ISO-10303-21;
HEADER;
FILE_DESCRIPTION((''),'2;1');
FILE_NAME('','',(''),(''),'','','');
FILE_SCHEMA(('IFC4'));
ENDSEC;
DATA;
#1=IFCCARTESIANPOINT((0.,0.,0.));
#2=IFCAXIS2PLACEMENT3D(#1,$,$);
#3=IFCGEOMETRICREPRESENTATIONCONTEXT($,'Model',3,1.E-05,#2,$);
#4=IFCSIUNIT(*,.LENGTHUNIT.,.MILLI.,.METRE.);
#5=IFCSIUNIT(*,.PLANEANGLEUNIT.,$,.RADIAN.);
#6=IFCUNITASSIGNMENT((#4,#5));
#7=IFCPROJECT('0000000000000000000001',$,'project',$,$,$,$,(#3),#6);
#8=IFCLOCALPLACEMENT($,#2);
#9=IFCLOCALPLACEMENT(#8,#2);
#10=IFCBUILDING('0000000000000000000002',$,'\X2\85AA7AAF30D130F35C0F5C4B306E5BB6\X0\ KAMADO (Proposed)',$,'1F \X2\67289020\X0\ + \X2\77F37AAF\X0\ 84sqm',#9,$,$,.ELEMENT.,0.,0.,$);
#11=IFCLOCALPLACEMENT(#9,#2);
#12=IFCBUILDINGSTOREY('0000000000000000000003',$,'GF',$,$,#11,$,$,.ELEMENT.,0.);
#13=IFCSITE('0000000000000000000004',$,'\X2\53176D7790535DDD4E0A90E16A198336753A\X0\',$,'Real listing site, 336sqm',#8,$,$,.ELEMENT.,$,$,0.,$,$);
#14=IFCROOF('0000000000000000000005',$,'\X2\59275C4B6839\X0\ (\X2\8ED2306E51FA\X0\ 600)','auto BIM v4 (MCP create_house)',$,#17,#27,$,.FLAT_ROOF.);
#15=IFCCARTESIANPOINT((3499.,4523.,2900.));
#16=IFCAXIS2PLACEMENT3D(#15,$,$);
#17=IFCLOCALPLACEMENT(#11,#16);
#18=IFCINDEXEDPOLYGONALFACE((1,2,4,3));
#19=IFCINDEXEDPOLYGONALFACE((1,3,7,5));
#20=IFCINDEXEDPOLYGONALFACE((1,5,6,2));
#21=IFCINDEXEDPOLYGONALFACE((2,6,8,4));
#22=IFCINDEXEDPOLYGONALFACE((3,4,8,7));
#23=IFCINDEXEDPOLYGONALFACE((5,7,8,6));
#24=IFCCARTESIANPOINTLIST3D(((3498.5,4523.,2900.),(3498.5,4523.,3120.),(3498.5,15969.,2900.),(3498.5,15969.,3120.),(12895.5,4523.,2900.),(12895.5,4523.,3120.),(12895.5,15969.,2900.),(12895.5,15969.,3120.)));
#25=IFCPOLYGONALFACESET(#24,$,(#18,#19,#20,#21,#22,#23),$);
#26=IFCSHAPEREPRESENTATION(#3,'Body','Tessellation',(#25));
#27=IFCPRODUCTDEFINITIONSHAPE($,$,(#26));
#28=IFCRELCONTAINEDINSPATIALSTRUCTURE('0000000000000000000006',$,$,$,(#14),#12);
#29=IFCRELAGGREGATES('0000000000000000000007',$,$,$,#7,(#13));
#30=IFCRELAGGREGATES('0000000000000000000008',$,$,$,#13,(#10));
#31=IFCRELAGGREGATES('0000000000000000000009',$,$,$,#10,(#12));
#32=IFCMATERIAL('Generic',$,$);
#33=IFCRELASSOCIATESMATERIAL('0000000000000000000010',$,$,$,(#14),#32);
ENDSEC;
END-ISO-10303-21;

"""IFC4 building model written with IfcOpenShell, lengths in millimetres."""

from ifc_helpers import new_model, si_unit, frame, frame_2d, origin, place, context, project, spatial, rectangle, extrude, material, element, save


model = new_model("IFC4")

# Units and contexts
model_context = context("Model", 3, precision=1e-05, world=origin())
ifc_project = project(units=[si_unit("LENGTHUNIT", "METRE", prefix="MILLI"), si_unit("PLANEANGLEUNIT", "RADIAN")], contexts=[model_context])

# Site, building, storey
site_placement = place(None, origin())
site = spatial("IfcSite", under=ifc_project, at=site_placement, Name="北海道川上郡標茶町", ObjectType="Real listing site, 336sqm", CompositionType="ELEMENT", RefElevation=0.0)
building_placement = place(site_placement, origin())
building = spatial("IfcBuilding", under=site, at=building_placement, Name="薪窯パン小屋の家 KAMADO (Proposed)", ObjectType="1F 木造 + 石窯 84sqm", CompositionType="ELEMENT", ElevationOfRefHeight=0.0, ElevationOfTerrain=0.0)
storey_placement = place(building_placement, origin())
storey = spatial("IfcBuildingStorey", under=building, at=storey_placement, Name="GF", CompositionType="ELEMENT", Elevation=0.0)

# Shared definitions
ifc_material = material(Name="Generic")

# Roof
roof_placement = place(storey_placement, frame((3499.0, 4523.0, 2900.0)))
element("IfcRoof", 1, at=roof_placement, inside=storey, material=ifc_material, Name="大屋根 (軒の出 600)", Description="auto BIM v4 (MCP create_house)", PredefinedType="FLAT_ROOF", context=model_context, shape_type="SweptSolid", body=[
    extrude(rectangle(XDim=9397.0, YDim=11446.0, at=frame_2d((4698.0, 5723.0))), frame((3499.0, 4523.0, 2900.0)), (0.0, 0.0, 1.0), 220.0),
])

save(model, "model.ifc")
